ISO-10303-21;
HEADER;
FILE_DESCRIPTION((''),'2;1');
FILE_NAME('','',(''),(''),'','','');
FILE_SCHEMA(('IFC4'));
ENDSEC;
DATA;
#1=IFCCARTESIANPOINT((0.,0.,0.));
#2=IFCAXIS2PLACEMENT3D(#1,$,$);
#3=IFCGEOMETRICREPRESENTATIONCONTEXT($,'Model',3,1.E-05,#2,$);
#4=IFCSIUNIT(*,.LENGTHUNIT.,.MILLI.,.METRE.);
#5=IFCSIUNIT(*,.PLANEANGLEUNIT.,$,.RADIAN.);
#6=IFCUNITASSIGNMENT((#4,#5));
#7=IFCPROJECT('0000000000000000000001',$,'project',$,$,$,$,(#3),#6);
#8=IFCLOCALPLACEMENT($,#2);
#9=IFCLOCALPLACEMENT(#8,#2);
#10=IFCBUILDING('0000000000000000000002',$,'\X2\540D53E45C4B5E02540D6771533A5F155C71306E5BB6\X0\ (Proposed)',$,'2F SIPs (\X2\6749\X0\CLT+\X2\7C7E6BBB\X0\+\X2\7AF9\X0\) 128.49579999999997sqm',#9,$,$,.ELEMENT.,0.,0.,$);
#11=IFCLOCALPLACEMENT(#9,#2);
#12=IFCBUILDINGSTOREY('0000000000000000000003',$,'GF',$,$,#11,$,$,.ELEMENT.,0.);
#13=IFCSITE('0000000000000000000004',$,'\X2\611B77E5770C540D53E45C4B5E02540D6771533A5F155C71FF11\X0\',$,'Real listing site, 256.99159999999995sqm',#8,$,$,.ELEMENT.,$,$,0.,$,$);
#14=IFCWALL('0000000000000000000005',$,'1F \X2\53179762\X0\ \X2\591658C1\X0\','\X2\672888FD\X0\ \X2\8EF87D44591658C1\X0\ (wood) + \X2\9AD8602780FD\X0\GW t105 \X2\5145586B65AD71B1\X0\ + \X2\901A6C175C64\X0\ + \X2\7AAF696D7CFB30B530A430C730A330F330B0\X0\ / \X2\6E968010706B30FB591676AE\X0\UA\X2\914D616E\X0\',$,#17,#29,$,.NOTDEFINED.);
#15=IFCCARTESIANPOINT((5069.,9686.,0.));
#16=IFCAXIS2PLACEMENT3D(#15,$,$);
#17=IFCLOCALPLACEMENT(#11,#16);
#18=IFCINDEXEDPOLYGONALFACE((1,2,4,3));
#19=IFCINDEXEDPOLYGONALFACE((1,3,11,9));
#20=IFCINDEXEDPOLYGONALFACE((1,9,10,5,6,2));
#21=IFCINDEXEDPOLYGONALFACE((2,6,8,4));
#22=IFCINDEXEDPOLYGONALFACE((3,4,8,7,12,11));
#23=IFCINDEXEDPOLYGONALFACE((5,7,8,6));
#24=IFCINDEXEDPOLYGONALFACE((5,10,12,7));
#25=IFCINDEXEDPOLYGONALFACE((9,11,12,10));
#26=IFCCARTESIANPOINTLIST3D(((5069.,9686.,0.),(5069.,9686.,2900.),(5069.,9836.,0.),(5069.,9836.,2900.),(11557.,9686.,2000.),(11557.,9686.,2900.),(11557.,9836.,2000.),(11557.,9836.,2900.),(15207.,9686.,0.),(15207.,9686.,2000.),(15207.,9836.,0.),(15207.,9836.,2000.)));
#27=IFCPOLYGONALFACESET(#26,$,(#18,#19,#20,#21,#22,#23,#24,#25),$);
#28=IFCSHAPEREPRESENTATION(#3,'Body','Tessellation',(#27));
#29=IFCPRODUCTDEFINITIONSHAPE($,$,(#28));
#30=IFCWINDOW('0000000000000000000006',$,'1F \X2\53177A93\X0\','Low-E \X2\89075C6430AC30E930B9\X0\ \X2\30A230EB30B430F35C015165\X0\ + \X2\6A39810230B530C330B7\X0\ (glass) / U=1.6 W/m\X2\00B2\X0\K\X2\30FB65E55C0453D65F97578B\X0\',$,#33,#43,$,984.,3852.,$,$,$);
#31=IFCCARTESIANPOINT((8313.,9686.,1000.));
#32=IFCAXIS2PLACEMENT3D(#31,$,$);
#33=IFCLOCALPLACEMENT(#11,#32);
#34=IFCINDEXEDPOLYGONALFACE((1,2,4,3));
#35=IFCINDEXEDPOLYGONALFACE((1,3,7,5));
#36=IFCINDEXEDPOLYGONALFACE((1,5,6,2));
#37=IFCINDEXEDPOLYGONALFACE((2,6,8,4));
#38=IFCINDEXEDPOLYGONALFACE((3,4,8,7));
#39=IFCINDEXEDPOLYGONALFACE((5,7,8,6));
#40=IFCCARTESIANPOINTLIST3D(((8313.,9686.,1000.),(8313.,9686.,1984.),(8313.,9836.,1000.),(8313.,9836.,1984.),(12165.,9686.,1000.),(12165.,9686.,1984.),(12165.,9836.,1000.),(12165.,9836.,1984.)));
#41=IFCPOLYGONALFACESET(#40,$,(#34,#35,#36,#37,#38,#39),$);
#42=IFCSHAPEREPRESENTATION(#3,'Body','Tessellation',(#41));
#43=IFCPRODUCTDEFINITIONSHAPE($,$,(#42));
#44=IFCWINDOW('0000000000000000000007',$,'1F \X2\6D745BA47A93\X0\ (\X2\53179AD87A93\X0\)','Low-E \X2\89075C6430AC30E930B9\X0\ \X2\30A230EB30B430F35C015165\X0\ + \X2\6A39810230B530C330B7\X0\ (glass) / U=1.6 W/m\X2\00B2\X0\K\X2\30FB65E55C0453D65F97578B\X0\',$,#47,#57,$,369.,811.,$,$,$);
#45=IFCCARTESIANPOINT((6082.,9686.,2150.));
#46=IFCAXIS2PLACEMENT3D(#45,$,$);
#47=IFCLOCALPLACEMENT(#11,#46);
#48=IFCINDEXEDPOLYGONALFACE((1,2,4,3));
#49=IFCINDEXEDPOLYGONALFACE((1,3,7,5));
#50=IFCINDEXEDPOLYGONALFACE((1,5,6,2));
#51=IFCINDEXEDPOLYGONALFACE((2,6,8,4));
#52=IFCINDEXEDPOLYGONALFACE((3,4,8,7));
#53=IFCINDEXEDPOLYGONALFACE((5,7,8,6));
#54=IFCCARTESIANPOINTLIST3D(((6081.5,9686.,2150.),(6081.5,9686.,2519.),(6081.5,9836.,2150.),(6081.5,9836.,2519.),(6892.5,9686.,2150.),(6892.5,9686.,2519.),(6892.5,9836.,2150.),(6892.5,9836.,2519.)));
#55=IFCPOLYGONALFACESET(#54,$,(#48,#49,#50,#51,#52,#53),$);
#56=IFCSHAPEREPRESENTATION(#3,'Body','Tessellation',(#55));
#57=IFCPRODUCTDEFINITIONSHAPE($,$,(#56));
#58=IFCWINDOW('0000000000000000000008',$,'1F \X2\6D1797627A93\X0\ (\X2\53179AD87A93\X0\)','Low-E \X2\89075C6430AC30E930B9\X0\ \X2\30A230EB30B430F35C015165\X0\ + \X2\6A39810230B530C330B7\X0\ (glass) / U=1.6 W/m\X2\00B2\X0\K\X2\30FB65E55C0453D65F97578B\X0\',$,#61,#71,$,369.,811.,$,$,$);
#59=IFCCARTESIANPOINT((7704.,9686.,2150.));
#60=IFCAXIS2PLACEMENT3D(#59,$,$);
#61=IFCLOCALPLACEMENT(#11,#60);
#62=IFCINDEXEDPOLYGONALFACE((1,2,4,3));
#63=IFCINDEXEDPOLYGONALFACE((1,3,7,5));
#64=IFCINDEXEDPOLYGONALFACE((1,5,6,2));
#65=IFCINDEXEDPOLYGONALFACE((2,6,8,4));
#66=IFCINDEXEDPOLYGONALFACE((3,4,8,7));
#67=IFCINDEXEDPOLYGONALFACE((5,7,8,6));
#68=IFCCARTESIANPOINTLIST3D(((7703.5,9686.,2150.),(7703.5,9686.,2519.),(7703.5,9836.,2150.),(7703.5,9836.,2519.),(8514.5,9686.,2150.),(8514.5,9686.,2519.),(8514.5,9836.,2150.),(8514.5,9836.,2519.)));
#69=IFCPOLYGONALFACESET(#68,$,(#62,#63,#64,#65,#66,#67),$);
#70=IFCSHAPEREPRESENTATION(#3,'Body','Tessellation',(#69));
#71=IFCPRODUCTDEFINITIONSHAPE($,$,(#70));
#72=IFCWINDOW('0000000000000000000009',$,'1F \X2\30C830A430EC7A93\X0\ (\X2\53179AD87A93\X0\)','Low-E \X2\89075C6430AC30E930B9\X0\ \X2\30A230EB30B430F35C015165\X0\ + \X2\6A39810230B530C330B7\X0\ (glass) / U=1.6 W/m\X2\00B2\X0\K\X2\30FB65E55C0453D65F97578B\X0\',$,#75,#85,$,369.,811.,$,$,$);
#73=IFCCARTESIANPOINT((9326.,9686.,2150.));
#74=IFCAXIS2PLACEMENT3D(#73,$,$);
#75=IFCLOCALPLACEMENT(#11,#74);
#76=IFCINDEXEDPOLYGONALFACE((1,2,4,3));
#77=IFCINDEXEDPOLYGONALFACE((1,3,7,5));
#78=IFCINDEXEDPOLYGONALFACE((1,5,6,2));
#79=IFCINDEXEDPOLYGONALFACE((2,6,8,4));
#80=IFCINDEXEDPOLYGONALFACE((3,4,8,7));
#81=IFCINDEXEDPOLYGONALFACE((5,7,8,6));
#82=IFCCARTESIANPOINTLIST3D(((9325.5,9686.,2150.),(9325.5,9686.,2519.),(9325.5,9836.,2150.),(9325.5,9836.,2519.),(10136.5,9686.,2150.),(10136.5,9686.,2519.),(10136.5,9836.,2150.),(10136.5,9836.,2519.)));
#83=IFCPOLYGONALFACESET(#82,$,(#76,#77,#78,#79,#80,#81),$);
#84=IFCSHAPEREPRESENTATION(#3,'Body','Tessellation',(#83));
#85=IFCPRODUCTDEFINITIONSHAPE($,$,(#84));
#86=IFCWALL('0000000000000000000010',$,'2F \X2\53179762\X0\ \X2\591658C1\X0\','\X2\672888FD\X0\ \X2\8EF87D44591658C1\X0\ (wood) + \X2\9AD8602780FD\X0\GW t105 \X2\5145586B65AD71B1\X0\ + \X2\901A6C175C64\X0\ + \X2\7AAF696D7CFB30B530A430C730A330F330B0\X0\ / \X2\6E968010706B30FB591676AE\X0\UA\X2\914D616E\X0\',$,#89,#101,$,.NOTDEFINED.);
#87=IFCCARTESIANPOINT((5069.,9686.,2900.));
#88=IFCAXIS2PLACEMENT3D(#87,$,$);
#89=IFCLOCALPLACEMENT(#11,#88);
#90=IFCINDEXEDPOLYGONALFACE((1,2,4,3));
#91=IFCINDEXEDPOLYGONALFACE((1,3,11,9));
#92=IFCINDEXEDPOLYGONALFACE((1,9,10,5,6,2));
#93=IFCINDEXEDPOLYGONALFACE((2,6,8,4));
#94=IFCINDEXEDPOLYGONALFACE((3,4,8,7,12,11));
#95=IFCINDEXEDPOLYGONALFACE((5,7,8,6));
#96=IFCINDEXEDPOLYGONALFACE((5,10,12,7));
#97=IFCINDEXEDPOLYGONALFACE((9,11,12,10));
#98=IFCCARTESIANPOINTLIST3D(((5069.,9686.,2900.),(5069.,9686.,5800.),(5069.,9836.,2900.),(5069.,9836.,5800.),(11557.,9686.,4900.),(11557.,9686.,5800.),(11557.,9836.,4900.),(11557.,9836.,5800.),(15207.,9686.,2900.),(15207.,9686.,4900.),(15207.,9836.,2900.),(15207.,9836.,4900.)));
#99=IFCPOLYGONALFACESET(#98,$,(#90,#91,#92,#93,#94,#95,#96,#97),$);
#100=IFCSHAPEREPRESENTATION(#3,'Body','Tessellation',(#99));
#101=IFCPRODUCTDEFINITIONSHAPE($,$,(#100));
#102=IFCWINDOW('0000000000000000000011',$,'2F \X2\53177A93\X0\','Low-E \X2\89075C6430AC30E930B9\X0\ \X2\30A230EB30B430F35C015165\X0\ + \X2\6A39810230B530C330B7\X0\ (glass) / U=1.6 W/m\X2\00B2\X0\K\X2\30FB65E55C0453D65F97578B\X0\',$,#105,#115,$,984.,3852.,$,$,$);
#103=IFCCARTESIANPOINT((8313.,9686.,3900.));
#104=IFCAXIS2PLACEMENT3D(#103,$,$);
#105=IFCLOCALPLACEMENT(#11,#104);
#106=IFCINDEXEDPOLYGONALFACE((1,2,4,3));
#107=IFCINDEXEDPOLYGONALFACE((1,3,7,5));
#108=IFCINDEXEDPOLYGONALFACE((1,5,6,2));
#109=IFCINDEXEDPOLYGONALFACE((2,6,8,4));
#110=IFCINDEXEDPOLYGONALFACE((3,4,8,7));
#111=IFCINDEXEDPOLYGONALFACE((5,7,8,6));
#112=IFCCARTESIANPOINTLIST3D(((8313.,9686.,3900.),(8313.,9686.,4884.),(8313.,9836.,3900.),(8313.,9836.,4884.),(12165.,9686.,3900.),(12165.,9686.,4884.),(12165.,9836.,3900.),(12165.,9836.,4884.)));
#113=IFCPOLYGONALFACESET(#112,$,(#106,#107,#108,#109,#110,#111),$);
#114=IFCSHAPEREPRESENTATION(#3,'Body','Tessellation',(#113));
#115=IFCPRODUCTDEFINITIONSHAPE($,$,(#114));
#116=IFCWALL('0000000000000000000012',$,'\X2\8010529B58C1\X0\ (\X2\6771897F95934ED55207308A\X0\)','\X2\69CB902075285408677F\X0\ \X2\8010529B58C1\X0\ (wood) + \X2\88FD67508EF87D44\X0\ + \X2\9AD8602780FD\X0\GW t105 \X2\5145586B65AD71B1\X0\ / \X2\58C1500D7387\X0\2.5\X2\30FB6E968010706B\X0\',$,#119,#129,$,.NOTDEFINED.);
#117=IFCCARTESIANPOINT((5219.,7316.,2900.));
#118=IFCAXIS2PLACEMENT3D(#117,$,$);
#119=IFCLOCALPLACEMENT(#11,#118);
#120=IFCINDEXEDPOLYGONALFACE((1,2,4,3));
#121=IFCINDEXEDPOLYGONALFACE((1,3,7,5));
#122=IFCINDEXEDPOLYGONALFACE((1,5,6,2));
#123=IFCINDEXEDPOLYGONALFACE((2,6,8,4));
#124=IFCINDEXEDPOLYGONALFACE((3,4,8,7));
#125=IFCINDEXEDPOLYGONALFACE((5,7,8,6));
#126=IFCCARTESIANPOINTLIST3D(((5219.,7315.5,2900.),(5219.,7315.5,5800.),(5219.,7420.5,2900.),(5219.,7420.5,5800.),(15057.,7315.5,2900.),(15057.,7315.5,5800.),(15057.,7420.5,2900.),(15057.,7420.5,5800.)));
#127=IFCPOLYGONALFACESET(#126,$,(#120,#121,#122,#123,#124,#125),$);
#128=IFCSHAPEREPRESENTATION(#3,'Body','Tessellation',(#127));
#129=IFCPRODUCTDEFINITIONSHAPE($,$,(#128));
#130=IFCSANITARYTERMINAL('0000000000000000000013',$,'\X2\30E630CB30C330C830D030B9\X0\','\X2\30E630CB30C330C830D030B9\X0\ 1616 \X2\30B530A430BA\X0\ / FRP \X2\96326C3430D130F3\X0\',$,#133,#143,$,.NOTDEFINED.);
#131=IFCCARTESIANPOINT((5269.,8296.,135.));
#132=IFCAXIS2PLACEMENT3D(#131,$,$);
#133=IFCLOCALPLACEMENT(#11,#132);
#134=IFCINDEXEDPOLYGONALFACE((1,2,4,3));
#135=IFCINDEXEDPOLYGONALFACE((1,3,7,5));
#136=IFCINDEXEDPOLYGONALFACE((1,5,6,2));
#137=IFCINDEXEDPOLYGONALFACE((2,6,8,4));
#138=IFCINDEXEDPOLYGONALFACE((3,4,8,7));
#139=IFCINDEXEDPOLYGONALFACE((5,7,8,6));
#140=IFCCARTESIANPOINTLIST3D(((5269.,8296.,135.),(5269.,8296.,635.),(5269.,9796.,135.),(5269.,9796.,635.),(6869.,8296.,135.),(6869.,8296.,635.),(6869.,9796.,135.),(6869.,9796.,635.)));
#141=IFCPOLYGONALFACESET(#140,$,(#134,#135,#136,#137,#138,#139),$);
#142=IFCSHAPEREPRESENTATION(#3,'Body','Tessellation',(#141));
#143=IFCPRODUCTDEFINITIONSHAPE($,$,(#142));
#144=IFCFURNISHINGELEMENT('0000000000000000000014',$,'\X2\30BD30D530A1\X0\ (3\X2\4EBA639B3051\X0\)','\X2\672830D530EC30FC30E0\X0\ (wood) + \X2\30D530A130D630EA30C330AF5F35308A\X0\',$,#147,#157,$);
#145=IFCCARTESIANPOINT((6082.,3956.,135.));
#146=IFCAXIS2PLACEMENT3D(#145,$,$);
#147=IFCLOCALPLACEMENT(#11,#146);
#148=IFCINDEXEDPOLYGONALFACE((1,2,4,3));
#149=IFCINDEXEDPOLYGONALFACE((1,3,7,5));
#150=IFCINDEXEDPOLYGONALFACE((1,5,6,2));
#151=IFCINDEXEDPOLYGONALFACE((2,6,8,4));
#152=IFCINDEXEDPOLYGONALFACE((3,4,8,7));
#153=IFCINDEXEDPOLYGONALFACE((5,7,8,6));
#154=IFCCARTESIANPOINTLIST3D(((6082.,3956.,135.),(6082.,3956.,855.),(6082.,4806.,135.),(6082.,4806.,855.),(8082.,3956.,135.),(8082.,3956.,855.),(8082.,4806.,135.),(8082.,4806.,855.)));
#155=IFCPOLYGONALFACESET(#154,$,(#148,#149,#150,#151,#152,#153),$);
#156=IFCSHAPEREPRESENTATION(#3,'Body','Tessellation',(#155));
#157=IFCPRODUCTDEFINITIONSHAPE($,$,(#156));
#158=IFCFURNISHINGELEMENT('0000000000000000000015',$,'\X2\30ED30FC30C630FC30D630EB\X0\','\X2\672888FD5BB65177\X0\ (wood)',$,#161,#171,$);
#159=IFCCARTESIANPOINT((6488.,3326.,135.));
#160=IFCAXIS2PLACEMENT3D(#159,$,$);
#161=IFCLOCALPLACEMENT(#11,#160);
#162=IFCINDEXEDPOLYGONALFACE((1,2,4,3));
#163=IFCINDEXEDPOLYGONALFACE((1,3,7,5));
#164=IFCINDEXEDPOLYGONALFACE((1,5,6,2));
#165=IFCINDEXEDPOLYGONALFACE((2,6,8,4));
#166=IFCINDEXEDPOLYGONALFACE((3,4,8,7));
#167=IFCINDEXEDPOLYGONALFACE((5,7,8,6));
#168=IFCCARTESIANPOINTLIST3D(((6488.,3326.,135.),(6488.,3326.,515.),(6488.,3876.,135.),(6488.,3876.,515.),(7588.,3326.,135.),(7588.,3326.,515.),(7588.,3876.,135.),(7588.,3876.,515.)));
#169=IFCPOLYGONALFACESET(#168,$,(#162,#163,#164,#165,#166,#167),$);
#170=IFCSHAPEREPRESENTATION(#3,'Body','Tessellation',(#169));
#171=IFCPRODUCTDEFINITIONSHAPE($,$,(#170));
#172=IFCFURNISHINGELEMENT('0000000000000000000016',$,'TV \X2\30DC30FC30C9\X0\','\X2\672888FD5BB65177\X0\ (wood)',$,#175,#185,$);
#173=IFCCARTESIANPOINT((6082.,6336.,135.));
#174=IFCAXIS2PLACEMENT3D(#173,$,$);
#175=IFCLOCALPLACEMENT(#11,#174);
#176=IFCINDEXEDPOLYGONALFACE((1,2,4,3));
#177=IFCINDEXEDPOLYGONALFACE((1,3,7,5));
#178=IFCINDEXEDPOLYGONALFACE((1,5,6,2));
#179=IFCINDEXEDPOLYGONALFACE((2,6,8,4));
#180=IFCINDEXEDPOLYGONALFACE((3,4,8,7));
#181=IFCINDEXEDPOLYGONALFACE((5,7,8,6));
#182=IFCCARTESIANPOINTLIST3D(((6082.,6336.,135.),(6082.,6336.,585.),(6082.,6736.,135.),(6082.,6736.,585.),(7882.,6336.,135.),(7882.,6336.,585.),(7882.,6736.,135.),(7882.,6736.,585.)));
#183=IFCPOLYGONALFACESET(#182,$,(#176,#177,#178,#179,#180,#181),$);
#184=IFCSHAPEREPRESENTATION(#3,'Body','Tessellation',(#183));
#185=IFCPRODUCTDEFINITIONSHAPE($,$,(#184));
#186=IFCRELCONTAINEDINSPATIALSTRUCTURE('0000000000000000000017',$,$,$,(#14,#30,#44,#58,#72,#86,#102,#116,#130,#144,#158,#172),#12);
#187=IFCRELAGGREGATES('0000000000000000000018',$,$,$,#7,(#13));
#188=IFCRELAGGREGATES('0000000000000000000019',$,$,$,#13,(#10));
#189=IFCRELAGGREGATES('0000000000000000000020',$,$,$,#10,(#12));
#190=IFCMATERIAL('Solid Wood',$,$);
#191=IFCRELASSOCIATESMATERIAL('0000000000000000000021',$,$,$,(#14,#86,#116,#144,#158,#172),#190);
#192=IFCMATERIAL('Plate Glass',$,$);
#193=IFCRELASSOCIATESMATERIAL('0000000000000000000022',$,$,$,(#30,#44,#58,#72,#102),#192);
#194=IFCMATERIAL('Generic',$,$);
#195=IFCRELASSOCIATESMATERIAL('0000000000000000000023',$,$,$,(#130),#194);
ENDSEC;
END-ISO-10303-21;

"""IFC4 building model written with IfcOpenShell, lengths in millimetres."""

from ifc_helpers import new_model, si_unit, frame, frame_2d, origin, place, context, project, spatial, rectangle, extrude, material, element, fill, save


model = new_model("IFC4")

# Units and contexts
model_context = context("Model", 3, precision=1e-05, world=origin())
ifc_project = project(units=[si_unit("LENGTHUNIT", "METRE", prefix="MILLI"), si_unit("PLANEANGLEUNIT", "RADIAN")], contexts=[model_context])

# Site, building, storey
site_placement = place(None, origin())
site = spatial("IfcSite", under=ifc_project, at=site_placement, Name="愛知県名古屋市名東区引山１", ObjectType="Real listing site, 256.99159999999995sqm", CompositionType="ELEMENT", RefElevation=0.0)
building_placement = place(site_placement, origin())
building = spatial("IfcBuilding", under=site, at=building_placement, Name="名古屋市名東区引山の家 (Proposed)", ObjectType="2F SIPs (杉CLT+籾殻+竹) 128.49579999999997sqm", CompositionType="ELEMENT", ElevationOfRefHeight=0.0, ElevationOfTerrain=0.0)
storey_placement = place(building_placement, origin())
storey = spatial("IfcBuildingStorey", under=building, at=storey_placement, Name="GF", CompositionType="ELEMENT", Elevation=0.0)

# Wall, openings, windows
ifc_material_1 = material(Name="Solid Wood")
wall_1_placement = place(storey_placement, frame((5069.0, 9686.0, 0.0)))
wall_1 = element("IfcWall", 1, at=wall_1_placement, inside=storey, material=ifc_material_1, Name="1F 北面 外壁", Description="木製 軸組外壁 (wood) + 高性能GW t105 充填断熱 + 通気層 + 窯業系サイディング / 準耐火・外皮UA配慮", PredefinedType="NOTDEFINED", context=model_context, shape_type="SweptSolid", body=[
    extrude(rectangle(XDim=10138.0, YDim=150.0, at=frame_2d((5069.0, 75.0))), frame((5069.0, 9686.0, 0.0)), (0.0, 0.0, 1.0), 2900.0),
])
opening_1_placement = place(storey_placement, frame((8313.0, 9686.0, 1000.0)))
opening_1 = element("IfcOpeningElement", 2, at=opening_1_placement, cuts=wall_1, PredefinedType="NOTDEFINED", context=model_context, shape_type="SweptSolid", body=[
    extrude(rectangle(XDim=3852.0, YDim=150.0, at=frame_2d((1926.0, 75.0))), frame((8313.0, 9686.0, 1000.0)), (0.0, 0.0, 1.0), 984.0),
])
opening_2_placement = place(storey_placement, frame((6082.0, 9686.0, 2150.0)))
opening_2 = element("IfcOpeningElement", 3, at=opening_2_placement, cuts=wall_1, PredefinedType="NOTDEFINED", context=model_context, shape_type="SweptSolid", body=[
    extrude(rectangle(XDim=811.0, YDim=150.0, at=frame_2d((405.0, 75.0))), frame((6082.0, 9686.0, 2150.0)), (0.0, 0.0, 1.0), 369.0),
])
opening_3_placement = place(storey_placement, frame((7704.0, 9686.0, 2150.0)))
opening_3 = element("IfcOpeningElement", 4, at=opening_3_placement, cuts=wall_1, PredefinedType="NOTDEFINED", context=model_context, shape_type="SweptSolid", body=[
    extrude(rectangle(XDim=811.0, YDim=150.0, at=frame_2d((405.0, 75.0))), frame((7704.0, 9686.0, 2150.0)), (0.0, 0.0, 1.0), 369.0),
])
opening_4_placement = place(storey_placement, frame((9326.0, 9686.0, 2150.0)))
opening_4 = element("IfcOpeningElement", 5, at=opening_4_placement, cuts=wall_1, PredefinedType="NOTDEFINED", context=model_context, shape_type="SweptSolid", body=[
    extrude(rectangle(XDim=811.0, YDim=150.0, at=frame_2d((405.0, 75.0))), frame((9326.0, 9686.0, 2150.0)), (0.0, 0.0, 1.0), 369.0),
])
ifc_material_2 = material(Name="Plate Glass")
window_1_placement = place(storey_placement, frame((8313.0, 9686.0, 1000.0)))
window_1 = element("IfcWindow", 6, at=window_1_placement, inside=storey, material=ifc_material_2, Name="1F 北窓", Description="Low-E 複層ガラス アルゴン封入 + 樹脂サッシ (glass) / U=1.6 W/m²K・日射取得型", OverallHeight=984.0, OverallWidth=3852.0, context=model_context, shape_type="SweptSolid", body=[
    extrude(rectangle(XDim=3852.0, YDim=150.0, at=frame_2d((1926.0, 75.0))), frame((8313.0, 9686.0, 1000.0)), (0.0, 0.0, 1.0), 984.0),
])
fill(opening_1, window_1)
window_2_placement = place(storey_placement, frame((6082.0, 9686.0, 2150.0)))
window_2 = element("IfcWindow", 7, at=window_2_placement, inside=storey, material=ifc_material_2, Name="1F 浴室窓 (北高窓)", Description="Low-E 複層ガラス アルゴン封入 + 樹脂サッシ (glass) / U=1.6 W/m²K・日射取得型", OverallHeight=369.0, OverallWidth=811.0, context=model_context, shape_type="SweptSolid", body=[
    extrude(rectangle(XDim=811.0, YDim=150.0, at=frame_2d((405.0, 75.0))), frame((6082.0, 9686.0, 2150.0)), (0.0, 0.0, 1.0), 369.0),
])
fill(opening_2, window_2)
window_3_placement = place(storey_placement, frame((7704.0, 9686.0, 2150.0)))
window_3 = element("IfcWindow", 8, at=window_3_placement, inside=storey, material=ifc_material_2, Name="1F 洗面窓 (北高窓)", Description="Low-E 複層ガラス アルゴン封入 + 樹脂サッシ (glass) / U=1.6 W/m²K・日射取得型", OverallHeight=369.0, OverallWidth=811.0, context=model_context, shape_type="SweptSolid", body=[
    extrude(rectangle(XDim=811.0, YDim=150.0, at=frame_2d((405.0, 75.0))), frame((7704.0, 9686.0, 2150.0)), (0.0, 0.0, 1.0), 369.0),
])
fill(opening_3, window_3)
window_4_placement = place(storey_placement, frame((9326.0, 9686.0, 2150.0)))
window_4 = element("IfcWindow", 9, at=window_4_placement, inside=storey, material=ifc_material_2, Name="1F トイレ窓 (北高窓)", Description="Low-E 複層ガラス アルゴン封入 + 樹脂サッシ (glass) / U=1.6 W/m²K・日射取得型", OverallHeight=369.0, OverallWidth=811.0, context=model_context, shape_type="SweptSolid", body=[
    extrude(rectangle(XDim=811.0, YDim=150.0, at=frame_2d((405.0, 75.0))), frame((9326.0, 9686.0, 2150.0)), (0.0, 0.0, 1.0), 369.0),
])
fill(opening_4, window_4)

# Wall, opening, window
wall_2_placement = place(storey_placement, frame((5069.0, 9686.0, 2900.0)))
wall_2 = element("IfcWall", 10, at=wall_2_placement, inside=storey, material=ifc_material_1, Name="2F 北面 外壁", Description="木製 軸組外壁 (wood) + 高性能GW t105 充填断熱 + 通気層 + 窯業系サイディング / 準耐火・外皮UA配慮", PredefinedType="NOTDEFINED", context=model_context, shape_type="SweptSolid", body=[
    extrude(rectangle(XDim=10138.0, YDim=150.0, at=frame_2d((5069.0, 75.0))), frame((5069.0, 9686.0, 2900.0)), (0.0, 0.0, 1.0), 2900.0),
])
opening_5_placement = place(storey_placement, frame((8313.0, 9686.0, 3900.0)))
opening_5 = element("IfcOpeningElement", 11, at=opening_5_placement, cuts=wall_2, PredefinedType="NOTDEFINED", context=model_context, shape_type="SweptSolid", body=[
    extrude(rectangle(XDim=3852.0, YDim=150.0, at=frame_2d((1926.0, 75.0))), frame((8313.0, 9686.0, 3900.0)), (0.0, 0.0, 1.0), 984.0),
])
window_5_placement = place(storey_placement, frame((8313.0, 9686.0, 3900.0)))
window_5 = element("IfcWindow", 12, at=window_5_placement, inside=storey, material=ifc_material_2, Name="2F 北窓", Description="Low-E 複層ガラス アルゴン封入 + 樹脂サッシ (glass) / U=1.6 W/m²K・日射取得型", OverallHeight=984.0, OverallWidth=3852.0, context=model_context, shape_type="SweptSolid", body=[
    extrude(rectangle(XDim=3852.0, YDim=150.0, at=frame_2d((1926.0, 75.0))), frame((8313.0, 9686.0, 3900.0)), (0.0, 0.0, 1.0), 984.0),
])
fill(opening_5, window_5)

# Wall
wall_3_placement = place(storey_placement, frame((5219.0, 7316.0, 2900.0)))
element("IfcWall", 13, at=wall_3_placement, inside=storey, material=ifc_material_1, Name="耐力壁 (東西間仕切り)", Description="構造用合板 耐力壁 (wood) + 製材軸組 + 高性能GW t105 充填断熱 / 壁倍率2.5・準耐火", PredefinedType="NOTDEFINED", context=model_context, shape_type="SweptSolid", body=[
    extrude(rectangle(XDim=9838.0, YDim=105.0, at=frame_2d((4919.0, 52.0))), frame((5219.0, 7316.0, 2900.0)), (0.0, 0.0, 1.0), 2900.0),
])

# Sanitary terminal
ifc_material_3 = material(Name="Generic")
sanitary_terminal_placement = place(storey_placement, frame((5269.0, 8296.0, 135.0)))
element("IfcSanitaryTerminal", 14, at=sanitary_terminal_placement, inside=storey, material=ifc_material_3, Name="ユニットバス", Description="ユニットバス 1616 サイズ / FRP 防水パン", PredefinedType="NOTDEFINED", context=model_context, shape_type="SweptSolid", body=[
    extrude(rectangle(XDim=1600.0, YDim=1500.0, at=frame_2d((800.0, 750.0))), frame((5269.0, 8296.0, 135.0)), (0.0, 0.0, 1.0), 500.0),
])

# Furnishing elements
furnishing_1_placement = place(storey_placement, frame((6082.0, 3956.0, 135.0)))
element("IfcFurnishingElement", 15, at=furnishing_1_placement, inside=storey, material=ifc_material_1, Name="ソファ (3人掛け)", Description="木フレーム (wood) + ファブリック張り", context=model_context, shape_type="SweptSolid", body=[
    extrude(rectangle(XDim=2000.0, YDim=850.0, at=frame_2d((1000.0, 425.0))), frame((6082.0, 3956.0, 135.0)), (0.0, 0.0, 1.0), 720.0),
])
furnishing_2_placement = place(storey_placement, frame((6488.0, 3326.0, 135.0)))
element("IfcFurnishingElement", 16, at=furnishing_2_placement, inside=storey, material=ifc_material_1, Name="ローテーブル", Description="木製家具 (wood)", context=model_context, shape_type="SweptSolid", body=[
    extrude(rectangle(XDim=1100.0, YDim=550.0, at=frame_2d((550.0, 275.0))), frame((6488.0, 3326.0, 135.0)), (0.0, 0.0, 1.0), 380.0),
])
furnishing_3_placement = place(storey_placement, frame((6082.0, 6336.0, 135.0)))
element("IfcFurnishingElement", 17, at=furnishing_3_placement, inside=storey, material=ifc_material_1, Name="TV ボード", Description="木製家具 (wood)", context=model_context, shape_type="SweptSolid", body=[
    extrude(rectangle(XDim=1800.0, YDim=400.0, at=frame_2d((900.0, 200.0))), frame((6082.0, 6336.0, 135.0)), (0.0, 0.0, 1.0), 450.0),
])

save(model, "model.ifc")
